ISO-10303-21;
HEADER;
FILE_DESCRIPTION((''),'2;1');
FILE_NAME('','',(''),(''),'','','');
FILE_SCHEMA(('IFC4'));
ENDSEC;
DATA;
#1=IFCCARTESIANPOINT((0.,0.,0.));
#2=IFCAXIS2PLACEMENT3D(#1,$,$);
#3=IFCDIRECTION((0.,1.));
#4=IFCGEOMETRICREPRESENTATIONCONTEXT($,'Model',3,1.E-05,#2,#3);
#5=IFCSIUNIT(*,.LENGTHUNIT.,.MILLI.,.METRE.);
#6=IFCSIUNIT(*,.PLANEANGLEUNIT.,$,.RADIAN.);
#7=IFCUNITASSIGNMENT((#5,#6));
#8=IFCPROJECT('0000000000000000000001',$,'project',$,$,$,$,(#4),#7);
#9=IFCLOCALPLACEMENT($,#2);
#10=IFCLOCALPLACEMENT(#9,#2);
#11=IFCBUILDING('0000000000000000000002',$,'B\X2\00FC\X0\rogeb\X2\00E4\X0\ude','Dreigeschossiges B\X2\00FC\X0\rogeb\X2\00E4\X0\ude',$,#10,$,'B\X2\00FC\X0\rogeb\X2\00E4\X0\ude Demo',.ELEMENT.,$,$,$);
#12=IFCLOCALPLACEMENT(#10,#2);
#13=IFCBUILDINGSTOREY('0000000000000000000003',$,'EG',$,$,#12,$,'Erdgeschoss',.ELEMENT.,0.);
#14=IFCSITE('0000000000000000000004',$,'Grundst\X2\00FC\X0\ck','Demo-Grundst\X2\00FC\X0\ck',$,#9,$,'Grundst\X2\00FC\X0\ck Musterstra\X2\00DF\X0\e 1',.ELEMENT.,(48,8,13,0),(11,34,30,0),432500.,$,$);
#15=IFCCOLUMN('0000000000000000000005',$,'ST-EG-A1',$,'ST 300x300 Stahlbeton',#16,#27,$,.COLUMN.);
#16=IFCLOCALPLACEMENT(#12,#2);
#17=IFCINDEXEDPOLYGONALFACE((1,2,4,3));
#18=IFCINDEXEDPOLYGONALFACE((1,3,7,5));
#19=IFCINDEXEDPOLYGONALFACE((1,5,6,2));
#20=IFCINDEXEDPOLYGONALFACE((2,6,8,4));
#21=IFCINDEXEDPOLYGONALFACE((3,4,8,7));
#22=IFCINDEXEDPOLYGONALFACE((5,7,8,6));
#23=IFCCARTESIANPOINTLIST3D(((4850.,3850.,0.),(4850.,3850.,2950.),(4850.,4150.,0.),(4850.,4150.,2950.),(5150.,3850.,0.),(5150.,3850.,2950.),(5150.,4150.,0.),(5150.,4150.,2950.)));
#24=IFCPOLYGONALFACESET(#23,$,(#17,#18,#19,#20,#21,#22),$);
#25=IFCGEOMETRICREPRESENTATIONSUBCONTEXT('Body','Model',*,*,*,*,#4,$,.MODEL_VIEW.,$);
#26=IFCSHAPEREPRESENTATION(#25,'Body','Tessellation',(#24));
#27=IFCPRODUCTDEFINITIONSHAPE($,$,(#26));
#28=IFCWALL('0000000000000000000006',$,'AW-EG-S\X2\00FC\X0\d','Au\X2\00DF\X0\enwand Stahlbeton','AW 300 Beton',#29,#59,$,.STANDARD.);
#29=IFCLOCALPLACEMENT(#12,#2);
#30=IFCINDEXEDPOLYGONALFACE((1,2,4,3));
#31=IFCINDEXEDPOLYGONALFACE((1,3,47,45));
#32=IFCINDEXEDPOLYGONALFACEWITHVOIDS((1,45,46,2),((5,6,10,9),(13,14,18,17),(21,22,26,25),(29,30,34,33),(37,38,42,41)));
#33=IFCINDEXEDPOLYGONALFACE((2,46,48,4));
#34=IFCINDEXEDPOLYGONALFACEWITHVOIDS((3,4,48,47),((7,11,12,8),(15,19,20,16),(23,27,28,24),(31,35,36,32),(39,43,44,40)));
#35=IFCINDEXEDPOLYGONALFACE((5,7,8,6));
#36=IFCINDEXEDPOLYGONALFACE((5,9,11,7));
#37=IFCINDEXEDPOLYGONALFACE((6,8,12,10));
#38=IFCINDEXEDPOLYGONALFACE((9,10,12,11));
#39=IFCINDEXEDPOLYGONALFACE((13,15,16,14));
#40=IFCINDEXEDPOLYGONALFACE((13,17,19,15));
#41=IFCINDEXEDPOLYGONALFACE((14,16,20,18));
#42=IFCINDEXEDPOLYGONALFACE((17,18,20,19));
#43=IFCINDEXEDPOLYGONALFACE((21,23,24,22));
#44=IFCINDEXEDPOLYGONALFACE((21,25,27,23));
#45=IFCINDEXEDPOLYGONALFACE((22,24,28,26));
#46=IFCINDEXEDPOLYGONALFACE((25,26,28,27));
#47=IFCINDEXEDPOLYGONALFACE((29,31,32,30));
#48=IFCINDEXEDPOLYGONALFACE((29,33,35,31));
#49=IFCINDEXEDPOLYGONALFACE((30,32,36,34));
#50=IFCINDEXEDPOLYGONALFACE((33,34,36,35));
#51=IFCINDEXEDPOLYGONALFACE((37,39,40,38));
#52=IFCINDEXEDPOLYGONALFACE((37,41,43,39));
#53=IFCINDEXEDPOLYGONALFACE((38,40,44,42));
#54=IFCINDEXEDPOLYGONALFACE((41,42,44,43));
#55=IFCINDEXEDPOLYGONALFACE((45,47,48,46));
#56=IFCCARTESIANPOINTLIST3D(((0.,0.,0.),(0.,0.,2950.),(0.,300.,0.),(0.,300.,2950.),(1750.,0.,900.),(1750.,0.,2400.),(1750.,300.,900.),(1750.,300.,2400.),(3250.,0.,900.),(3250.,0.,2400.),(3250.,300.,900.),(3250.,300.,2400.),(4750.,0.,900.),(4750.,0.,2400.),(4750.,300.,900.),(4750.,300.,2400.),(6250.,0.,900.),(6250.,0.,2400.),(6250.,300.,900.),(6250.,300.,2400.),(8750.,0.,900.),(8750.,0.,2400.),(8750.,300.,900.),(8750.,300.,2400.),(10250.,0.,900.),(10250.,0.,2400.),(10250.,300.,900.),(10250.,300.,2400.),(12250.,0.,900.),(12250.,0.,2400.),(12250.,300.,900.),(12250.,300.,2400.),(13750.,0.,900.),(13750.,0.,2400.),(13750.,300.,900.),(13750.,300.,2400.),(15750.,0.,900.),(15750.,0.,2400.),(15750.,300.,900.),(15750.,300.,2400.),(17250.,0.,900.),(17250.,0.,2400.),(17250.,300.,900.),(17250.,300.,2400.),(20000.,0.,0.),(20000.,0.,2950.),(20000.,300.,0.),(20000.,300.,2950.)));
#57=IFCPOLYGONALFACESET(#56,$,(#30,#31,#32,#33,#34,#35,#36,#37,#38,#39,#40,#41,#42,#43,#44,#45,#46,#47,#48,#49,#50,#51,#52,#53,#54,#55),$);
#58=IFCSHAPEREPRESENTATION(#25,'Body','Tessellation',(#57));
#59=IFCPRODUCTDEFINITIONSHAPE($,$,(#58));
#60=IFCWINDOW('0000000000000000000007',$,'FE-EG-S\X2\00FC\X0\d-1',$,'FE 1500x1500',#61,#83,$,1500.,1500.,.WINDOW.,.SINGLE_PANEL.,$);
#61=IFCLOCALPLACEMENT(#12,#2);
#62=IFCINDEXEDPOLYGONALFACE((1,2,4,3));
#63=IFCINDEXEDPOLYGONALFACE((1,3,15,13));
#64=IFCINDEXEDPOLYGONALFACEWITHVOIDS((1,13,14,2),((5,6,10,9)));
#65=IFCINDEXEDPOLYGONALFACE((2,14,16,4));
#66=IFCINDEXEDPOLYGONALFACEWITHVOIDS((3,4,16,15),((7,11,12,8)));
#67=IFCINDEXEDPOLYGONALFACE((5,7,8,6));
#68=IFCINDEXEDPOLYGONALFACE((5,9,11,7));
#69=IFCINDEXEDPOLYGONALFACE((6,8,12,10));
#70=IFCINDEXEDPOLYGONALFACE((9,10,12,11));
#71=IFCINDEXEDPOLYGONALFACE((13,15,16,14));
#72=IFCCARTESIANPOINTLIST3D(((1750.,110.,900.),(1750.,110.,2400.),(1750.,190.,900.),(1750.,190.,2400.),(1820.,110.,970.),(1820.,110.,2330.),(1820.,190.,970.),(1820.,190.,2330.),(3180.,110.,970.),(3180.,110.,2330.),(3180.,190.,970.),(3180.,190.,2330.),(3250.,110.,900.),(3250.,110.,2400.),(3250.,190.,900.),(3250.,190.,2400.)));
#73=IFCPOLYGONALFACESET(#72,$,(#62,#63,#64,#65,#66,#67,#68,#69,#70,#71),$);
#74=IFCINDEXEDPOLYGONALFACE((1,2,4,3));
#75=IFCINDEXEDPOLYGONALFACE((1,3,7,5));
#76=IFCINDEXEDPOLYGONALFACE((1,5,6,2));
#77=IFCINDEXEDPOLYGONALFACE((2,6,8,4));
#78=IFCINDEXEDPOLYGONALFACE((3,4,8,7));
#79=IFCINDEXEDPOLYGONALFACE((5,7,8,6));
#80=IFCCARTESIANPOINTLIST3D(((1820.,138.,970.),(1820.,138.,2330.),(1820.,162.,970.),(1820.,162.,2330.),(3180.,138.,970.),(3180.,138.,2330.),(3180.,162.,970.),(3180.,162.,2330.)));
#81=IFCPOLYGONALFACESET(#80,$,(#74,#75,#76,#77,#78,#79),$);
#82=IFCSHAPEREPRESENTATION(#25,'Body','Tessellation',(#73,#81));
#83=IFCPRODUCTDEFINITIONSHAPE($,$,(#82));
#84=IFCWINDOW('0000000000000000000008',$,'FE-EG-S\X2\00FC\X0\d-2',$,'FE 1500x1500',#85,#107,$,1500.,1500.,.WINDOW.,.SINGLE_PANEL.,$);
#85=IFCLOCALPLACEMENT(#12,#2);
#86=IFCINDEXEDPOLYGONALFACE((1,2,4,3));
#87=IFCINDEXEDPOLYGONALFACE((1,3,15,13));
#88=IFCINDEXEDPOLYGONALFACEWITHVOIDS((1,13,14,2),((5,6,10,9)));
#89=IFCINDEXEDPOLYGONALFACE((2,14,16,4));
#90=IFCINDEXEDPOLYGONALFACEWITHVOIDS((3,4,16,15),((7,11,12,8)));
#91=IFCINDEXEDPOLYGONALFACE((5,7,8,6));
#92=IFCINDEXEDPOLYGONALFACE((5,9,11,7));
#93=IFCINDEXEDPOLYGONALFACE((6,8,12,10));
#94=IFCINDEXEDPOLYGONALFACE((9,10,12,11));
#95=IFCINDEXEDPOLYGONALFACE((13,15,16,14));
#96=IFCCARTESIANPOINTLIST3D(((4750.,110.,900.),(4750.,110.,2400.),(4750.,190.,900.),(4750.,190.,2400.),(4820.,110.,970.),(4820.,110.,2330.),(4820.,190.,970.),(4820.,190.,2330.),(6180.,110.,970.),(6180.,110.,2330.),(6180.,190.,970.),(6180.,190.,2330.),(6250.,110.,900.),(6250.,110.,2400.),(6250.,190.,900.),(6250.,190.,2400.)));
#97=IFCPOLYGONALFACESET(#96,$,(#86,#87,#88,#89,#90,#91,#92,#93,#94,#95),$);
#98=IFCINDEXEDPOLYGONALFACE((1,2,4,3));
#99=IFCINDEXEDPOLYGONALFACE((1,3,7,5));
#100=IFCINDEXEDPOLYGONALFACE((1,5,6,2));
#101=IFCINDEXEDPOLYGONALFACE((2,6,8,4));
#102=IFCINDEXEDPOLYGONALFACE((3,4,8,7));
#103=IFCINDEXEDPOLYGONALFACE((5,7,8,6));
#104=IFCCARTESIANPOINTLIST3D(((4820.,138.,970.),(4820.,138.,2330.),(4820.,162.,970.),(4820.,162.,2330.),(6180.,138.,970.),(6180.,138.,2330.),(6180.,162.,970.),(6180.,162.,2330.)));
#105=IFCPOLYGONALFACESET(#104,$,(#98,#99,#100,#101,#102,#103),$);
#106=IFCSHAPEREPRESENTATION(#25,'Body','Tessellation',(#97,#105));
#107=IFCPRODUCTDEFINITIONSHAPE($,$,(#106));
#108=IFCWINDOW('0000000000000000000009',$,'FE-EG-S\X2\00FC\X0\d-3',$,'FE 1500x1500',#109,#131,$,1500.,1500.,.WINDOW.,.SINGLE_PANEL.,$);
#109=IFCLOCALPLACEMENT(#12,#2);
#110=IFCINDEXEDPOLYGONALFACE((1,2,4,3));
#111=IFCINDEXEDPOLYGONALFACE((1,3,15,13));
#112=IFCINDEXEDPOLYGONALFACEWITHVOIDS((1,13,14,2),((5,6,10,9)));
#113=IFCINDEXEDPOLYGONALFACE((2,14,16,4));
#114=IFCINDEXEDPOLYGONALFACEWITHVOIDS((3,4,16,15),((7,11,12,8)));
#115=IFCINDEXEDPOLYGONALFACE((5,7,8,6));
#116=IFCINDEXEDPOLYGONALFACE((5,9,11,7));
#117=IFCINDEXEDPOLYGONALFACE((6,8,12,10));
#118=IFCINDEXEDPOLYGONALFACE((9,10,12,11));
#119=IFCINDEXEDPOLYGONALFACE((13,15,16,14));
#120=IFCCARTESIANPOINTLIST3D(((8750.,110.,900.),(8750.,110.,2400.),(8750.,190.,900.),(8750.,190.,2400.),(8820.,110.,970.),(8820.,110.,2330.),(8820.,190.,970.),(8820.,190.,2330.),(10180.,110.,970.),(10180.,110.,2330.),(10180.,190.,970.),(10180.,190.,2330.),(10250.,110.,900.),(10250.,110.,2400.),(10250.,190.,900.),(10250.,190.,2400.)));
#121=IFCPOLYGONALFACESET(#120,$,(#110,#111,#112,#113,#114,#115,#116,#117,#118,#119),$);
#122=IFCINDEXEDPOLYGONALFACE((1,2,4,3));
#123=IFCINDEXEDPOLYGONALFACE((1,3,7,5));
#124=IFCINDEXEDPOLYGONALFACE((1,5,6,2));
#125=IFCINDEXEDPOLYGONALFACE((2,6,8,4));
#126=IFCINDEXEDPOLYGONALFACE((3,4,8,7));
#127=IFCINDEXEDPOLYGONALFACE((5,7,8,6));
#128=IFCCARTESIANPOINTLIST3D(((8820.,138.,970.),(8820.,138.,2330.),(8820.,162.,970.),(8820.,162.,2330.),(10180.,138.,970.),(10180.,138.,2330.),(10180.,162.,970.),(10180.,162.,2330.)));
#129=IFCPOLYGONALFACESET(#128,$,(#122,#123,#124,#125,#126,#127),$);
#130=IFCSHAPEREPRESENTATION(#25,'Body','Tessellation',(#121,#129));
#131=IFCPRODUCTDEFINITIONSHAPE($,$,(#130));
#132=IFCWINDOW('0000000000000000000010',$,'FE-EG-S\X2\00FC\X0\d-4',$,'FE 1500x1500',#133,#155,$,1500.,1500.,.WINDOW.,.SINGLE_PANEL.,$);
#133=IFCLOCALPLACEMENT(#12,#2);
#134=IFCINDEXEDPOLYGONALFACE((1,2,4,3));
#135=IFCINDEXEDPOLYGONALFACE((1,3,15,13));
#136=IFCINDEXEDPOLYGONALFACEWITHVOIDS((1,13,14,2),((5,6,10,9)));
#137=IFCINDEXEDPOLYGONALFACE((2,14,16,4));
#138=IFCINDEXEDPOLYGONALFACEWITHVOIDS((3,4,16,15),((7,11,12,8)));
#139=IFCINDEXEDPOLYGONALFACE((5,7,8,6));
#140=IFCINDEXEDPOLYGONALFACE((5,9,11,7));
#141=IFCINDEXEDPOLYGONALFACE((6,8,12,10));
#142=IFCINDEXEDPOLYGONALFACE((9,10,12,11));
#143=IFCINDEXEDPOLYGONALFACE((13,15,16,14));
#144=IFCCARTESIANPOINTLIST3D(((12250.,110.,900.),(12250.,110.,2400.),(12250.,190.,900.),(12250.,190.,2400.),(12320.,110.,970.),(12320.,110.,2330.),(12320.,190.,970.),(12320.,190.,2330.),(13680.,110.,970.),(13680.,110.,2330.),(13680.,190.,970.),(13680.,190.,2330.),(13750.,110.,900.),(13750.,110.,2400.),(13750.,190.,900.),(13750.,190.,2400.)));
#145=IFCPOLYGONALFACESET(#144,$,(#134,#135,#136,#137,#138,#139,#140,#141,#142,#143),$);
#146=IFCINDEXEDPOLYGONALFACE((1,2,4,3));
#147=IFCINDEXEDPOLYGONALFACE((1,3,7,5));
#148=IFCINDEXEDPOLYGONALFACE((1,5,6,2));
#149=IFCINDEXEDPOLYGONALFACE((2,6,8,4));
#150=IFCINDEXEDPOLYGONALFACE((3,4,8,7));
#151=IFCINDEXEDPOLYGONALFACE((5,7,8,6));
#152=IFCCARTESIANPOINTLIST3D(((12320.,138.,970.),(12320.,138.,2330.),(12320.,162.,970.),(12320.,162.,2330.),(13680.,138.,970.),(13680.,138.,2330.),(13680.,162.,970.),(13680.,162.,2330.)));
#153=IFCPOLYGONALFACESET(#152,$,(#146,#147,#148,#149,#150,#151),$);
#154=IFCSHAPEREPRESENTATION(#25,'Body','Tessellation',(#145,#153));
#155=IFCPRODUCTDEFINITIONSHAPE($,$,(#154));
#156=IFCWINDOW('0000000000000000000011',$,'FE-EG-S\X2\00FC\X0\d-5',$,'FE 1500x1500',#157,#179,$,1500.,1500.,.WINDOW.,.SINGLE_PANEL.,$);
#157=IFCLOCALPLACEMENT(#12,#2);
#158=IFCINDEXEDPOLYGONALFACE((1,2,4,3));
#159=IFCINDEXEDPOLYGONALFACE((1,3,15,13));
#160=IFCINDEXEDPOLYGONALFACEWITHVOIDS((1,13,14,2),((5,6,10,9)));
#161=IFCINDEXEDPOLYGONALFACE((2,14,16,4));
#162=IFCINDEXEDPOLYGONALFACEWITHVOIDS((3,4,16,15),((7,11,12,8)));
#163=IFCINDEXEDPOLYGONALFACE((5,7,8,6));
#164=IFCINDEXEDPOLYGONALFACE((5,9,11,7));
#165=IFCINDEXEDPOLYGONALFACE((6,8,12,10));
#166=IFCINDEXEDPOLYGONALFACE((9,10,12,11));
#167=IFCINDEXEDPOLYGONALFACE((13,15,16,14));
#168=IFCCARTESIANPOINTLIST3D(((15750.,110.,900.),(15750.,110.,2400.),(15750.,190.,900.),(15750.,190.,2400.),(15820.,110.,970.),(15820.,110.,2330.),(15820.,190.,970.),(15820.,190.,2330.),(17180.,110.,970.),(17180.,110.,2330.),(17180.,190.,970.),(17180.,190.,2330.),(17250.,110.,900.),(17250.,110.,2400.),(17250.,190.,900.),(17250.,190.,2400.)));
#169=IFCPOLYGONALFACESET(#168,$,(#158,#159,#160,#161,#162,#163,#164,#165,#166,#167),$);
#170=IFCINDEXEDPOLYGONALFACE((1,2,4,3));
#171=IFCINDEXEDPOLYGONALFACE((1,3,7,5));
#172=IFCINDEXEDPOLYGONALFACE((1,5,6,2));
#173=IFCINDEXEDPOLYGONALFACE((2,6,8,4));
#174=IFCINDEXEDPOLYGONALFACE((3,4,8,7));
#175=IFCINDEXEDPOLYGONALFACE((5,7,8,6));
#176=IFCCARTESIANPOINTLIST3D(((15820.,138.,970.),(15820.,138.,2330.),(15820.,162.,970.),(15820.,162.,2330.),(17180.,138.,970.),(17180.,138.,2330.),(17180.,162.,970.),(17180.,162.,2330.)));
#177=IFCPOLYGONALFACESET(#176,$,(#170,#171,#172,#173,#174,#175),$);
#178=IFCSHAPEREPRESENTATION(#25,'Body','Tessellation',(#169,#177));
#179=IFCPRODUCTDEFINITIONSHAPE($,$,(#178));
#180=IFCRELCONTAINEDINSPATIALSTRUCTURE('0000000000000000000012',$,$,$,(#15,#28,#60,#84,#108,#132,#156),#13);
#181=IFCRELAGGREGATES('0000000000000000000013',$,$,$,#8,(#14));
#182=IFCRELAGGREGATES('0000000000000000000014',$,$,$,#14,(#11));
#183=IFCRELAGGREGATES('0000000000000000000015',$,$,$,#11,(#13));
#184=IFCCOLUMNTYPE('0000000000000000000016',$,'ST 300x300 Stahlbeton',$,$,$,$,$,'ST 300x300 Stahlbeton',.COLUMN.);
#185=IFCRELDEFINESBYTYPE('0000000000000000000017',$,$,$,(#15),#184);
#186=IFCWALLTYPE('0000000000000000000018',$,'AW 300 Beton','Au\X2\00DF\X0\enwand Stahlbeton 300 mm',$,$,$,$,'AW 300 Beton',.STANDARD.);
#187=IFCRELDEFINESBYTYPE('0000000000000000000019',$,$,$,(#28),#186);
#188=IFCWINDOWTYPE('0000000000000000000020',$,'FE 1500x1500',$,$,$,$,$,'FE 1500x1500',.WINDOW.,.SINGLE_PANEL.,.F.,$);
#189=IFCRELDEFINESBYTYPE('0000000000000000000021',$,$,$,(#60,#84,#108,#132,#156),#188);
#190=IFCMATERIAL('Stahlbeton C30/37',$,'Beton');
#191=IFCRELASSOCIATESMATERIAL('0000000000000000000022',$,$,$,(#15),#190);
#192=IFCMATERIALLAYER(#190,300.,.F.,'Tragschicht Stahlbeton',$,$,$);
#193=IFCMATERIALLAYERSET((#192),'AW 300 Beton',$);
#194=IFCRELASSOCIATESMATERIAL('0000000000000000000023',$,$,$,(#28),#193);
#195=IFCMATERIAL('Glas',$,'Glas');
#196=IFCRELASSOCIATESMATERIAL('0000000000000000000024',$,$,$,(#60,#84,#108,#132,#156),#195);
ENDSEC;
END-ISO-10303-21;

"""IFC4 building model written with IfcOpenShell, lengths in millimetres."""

from ifc_helpers import new_model, si_unit, direction, frame, frame_2d, origin, origin_2d, place, context, subcontext, project, spatial, polyline, rectangle, outline, extrude, material, layer, layer_set, layer_usage, type_object, element, fill, save


model = new_model("IFC4")

# Units and contexts
model_context = context("Model", 3, precision=1e-05, world=origin(), true_north=direction((0.0, 1.0)))
body_context = subcontext(model_context, "Body", "Model", "MODEL_VIEW")
ifc_project = project(units=[si_unit("LENGTHUNIT", "METRE", prefix="MILLI"), si_unit("PLANEANGLEUNIT", "RADIAN")], contexts=[model_context])

# Site, building, storey
site_placement = place(None, origin())
site = spatial("IfcSite", under=ifc_project, at=site_placement, Name="Grundstück", Description="Demo-Grundstück", LongName="Grundstück Musterstraße 1", CompositionType="ELEMENT", RefLatitude=(48, 8, 13, 0), RefLongitude=(11, 34, 30, 0), RefElevation=432500.0)
building_placement = place(site_placement, origin())
building = spatial("IfcBuilding", under=site, at=building_placement, Name="Bürogebäude", Description="Dreigeschossiges Bürogebäude", LongName="Bürogebäude Demo", CompositionType="ELEMENT")
storey_placement = place(building_placement, origin())
storey = spatial("IfcBuildingStorey", under=building, at=storey_placement, Name="EG", LongName="Erdgeschoss", CompositionType="ELEMENT", Elevation=0.0)

# Column
ifc_material_1 = material(Name="Stahlbeton C30/37", Category="Beton")
column_type = type_object("IfcColumnType", Name="ST 300x300 Stahlbeton", ElementType="ST 300x300 Stahlbeton", PredefinedType="COLUMN")
column_placement = place(storey_placement, frame((5000.0, 4000.0, 0.0)))
element("IfcColumn", 1, at=column_placement, inside=storey, type_object=column_type, material=ifc_material_1, Name="ST-EG-A1", ObjectType="ST 300x300 Stahlbeton", PredefinedType="COLUMN", context=body_context, shape_type="SweptSolid", body=[
    extrude(rectangle(XDim=300.0, YDim=300.0, at=origin_2d()), origin(), (0.0, 0.0, 1.0), 2950.0),
])

# Wall, openings, windows
ifc_layer = layer(ifc_material_1, 300.0, ventilated=False, Name="Tragschicht Stahlbeton")
ifc_layer_set = layer_set([ifc_layer], Name="AW 300 Beton")
ifc_layer_usage = layer_usage(ifc_layer_set, "AXIS2", "POSITIVE", -150.0)
wall_type = type_object("IfcWallType", Name="AW 300 Beton", Description="Außenwand Stahlbeton 300 mm", ElementType="AW 300 Beton", PredefinedType="STANDARD")
wall_1_placement = place(storey_placement, frame((0.0, 150.0, 0.0)))
wall_1 = element("IfcWall", 2, at=wall_1_placement, inside=storey, type_object=wall_type, material=ifc_layer_usage, Name="AW-EG-Süd", Description="Außenwand Stahlbeton", ObjectType="AW 300 Beton", PredefinedType="STANDARD", context=body_context, shape_type="SweptSolid", body=[
    extrude(rectangle(XDim=20000.0, YDim=300.0, at=frame_2d((10000.0, 0.0))), origin(), (0.0, 0.0, 1.0), 2950.0),
])
opening_1_placement = place(wall_1_placement, frame((2500.0, 0.0, 900.0)))
opening_1 = element("IfcOpeningElement", 3, at=opening_1_placement, cuts=wall_1, PredefinedType="OPENING", context=body_context, shape_type="SweptSolid", body=[
    extrude(rectangle(XDim=1500.0, YDim=340.0, at=origin_2d()), origin(), (0.0, 0.0, 1.0), 1500.0),
])
opening_2_placement = place(wall_1_placement, frame((5500.0, 0.0, 900.0)))
opening_2 = element("IfcOpeningElement", 4, at=opening_2_placement, cuts=wall_1, PredefinedType="OPENING", context=body_context, shape_type="SweptSolid", body=[
    extrude(rectangle(XDim=1500.0, YDim=340.0, at=origin_2d()), origin(), (0.0, 0.0, 1.0), 1500.0),
])
opening_3_placement = place(wall_1_placement, frame((9500.0, 0.0, 900.0)))
opening_3 = element("IfcOpeningElement", 5, at=opening_3_placement, cuts=wall_1, PredefinedType="OPENING", context=body_context, shape_type="SweptSolid", body=[
    extrude(rectangle(XDim=1500.0, YDim=340.0, at=origin_2d()), origin(), (0.0, 0.0, 1.0), 1500.0),
])
opening_4_placement = place(wall_1_placement, frame((13000.0, 0.0, 900.0)))
opening_4 = element("IfcOpeningElement", 6, at=opening_4_placement, cuts=wall_1, PredefinedType="OPENING", context=body_context, shape_type="SweptSolid", body=[
    extrude(rectangle(XDim=1500.0, YDim=340.0, at=origin_2d()), origin(), (0.0, 0.0, 1.0), 1500.0),
])
opening_5_placement = place(wall_1_placement, frame((16500.0, 0.0, 900.0)))
opening_5 = element("IfcOpeningElement", 7, at=opening_5_placement, cuts=wall_1, PredefinedType="OPENING", context=body_context, shape_type="SweptSolid", body=[
    extrude(rectangle(XDim=1500.0, YDim=340.0, at=origin_2d()), origin(), (0.0, 0.0, 1.0), 1500.0),
])
ifc_material_2 = material(Name="Glas", Category="Glas")
window_type = type_object("IfcWindowType", Name="FE 1500x1500", ElementType="FE 1500x1500", ParameterTakesPrecedence=False, PartitioningType="SINGLE_PANEL", PredefinedType="WINDOW")
window_1_placement = place(opening_1_placement, origin())
window_1 = element("IfcWindow", 8, at=window_1_placement, inside=storey, type_object=window_type, material=ifc_material_2, Name="FE-EG-Süd-1", ObjectType="FE 1500x1500", OverallHeight=1500.0, OverallWidth=1500.0, PartitioningType="SINGLE_PANEL", PredefinedType="WINDOW", context=body_context, shape_type="SweptSolid", body=[
    extrude(outline(polyline([(-750.0, 0.0), (750.0, 0.0), (750.0, 1500.0), (-750.0, 1500.0), (-750.0, 0.0)]), holes=[polyline([(-680.0, 70.0), (680.0, 70.0), (680.0, 1430.0), (-680.0, 1430.0), (-680.0, 70.0)])]), frame((0.0, 40.0, 0.0), z_axis=(0.0, -1.0, 0.0), x_axis=(1.0, 0.0, 0.0)), (0.0, 0.0, 1.0), 80.0),
    extrude(rectangle(XDim=1360.0, YDim=24.0, at=origin_2d()), frame((0.0, 0.0, 70.0)), (0.0, 0.0, 1.0), 1360.0),
])
fill(opening_1, window_1)
window_2_placement = place(opening_2_placement, origin())
window_2 = element("IfcWindow", 9, at=window_2_placement, inside=storey, type_object=window_type, material=ifc_material_2, Name="FE-EG-Süd-2", ObjectType="FE 1500x1500", OverallHeight=1500.0, OverallWidth=1500.0, PartitioningType="SINGLE_PANEL", PredefinedType="WINDOW", context=body_context, shape_type="SweptSolid", body=[
    extrude(outline(polyline([(-750.0, 0.0), (750.0, 0.0), (750.0, 1500.0), (-750.0, 1500.0), (-750.0, 0.0)]), holes=[polyline([(-680.0, 70.0), (680.0, 70.0), (680.0, 1430.0), (-680.0, 1430.0), (-680.0, 70.0)])]), frame((0.0, 40.0, 0.0), z_axis=(0.0, -1.0, 0.0), x_axis=(1.0, 0.0, 0.0)), (0.0, 0.0, 1.0), 80.0),
    extrude(rectangle(XDim=1360.0, YDim=24.0, at=origin_2d()), frame((0.0, 0.0, 70.0)), (0.0, 0.0, 1.0), 1360.0),
])
fill(opening_2, window_2)
window_3_placement = place(opening_3_placement, origin())
window_3 = element("IfcWindow", 10, at=window_3_placement, inside=storey, type_object=window_type, material=ifc_material_2, Name="FE-EG-Süd-3", ObjectType="FE 1500x1500", OverallHeight=1500.0, OverallWidth=1500.0, PartitioningType="SINGLE_PANEL", PredefinedType="WINDOW", context=body_context, shape_type="SweptSolid", body=[
    extrude(outline(polyline([(-750.0, 0.0), (750.0, 0.0), (750.0, 1500.0), (-750.0, 1500.0), (-750.0, 0.0)]), holes=[polyline([(-680.0, 70.0), (680.0, 70.0), (680.0, 1430.0), (-680.0, 1430.0), (-680.0, 70.0)])]), frame((0.0, 40.0, 0.0), z_axis=(0.0, -1.0, 0.0), x_axis=(1.0, 0.0, 0.0)), (0.0, 0.0, 1.0), 80.0),
    extrude(rectangle(XDim=1360.0, YDim=24.0, at=origin_2d()), frame((0.0, 0.0, 70.0)), (0.0, 0.0, 1.0), 1360.0),
])
fill(opening_3, window_3)
window_4_placement = place(opening_4_placement, origin())
window_4 = element("IfcWindow", 11, at=window_4_placement, inside=storey, type_object=window_type, material=ifc_material_2, Name="FE-EG-Süd-4", ObjectType="FE 1500x1500", OverallHeight=1500.0, OverallWidth=1500.0, PartitioningType="SINGLE_PANEL", PredefinedType="WINDOW", context=body_context, shape_type="SweptSolid", body=[
    extrude(outline(polyline([(-750.0, 0.0), (750.0, 0.0), (750.0, 1500.0), (-750.0, 1500.0), (-750.0, 0.0)]), holes=[polyline([(-680.0, 70.0), (680.0, 70.0), (680.0, 1430.0), (-680.0, 1430.0), (-680.0, 70.0)])]), frame((0.0, 40.0, 0.0), z_axis=(0.0, -1.0, 0.0), x_axis=(1.0, 0.0, 0.0)), (0.0, 0.0, 1.0), 80.0),
    extrude(rectangle(XDim=1360.0, YDim=24.0, at=origin_2d()), frame((0.0, 0.0, 70.0)), (0.0, 0.0, 1.0), 1360.0),
])
fill(opening_4, window_4)
window_5_placement = place(opening_5_placement, origin())
window_5 = element("IfcWindow", 12, at=window_5_placement, inside=storey, type_object=window_type, material=ifc_material_2, Name="FE-EG-Süd-5", ObjectType="FE 1500x1500", OverallHeight=1500.0, OverallWidth=1500.0, PartitioningType="SINGLE_PANEL", PredefinedType="WINDOW", context=body_context, shape_type="SweptSolid", body=[
    extrude(outline(polyline([(-750.0, 0.0), (750.0, 0.0), (750.0, 1500.0), (-750.0, 1500.0), (-750.0, 0.0)]), holes=[polyline([(-680.0, 70.0), (680.0, 70.0), (680.0, 1430.0), (-680.0, 1430.0), (-680.0, 70.0)])]), frame((0.0, 40.0, 0.0), z_axis=(0.0, -1.0, 0.0), x_axis=(1.0, 0.0, 0.0)), (0.0, 0.0, 1.0), 80.0),
    extrude(rectangle(XDim=1360.0, YDim=24.0, at=origin_2d()), frame((0.0, 0.0, 70.0)), (0.0, 0.0, 1.0), 1360.0),
])
fill(opening_5, window_5)

save(model, "model.ifc")
